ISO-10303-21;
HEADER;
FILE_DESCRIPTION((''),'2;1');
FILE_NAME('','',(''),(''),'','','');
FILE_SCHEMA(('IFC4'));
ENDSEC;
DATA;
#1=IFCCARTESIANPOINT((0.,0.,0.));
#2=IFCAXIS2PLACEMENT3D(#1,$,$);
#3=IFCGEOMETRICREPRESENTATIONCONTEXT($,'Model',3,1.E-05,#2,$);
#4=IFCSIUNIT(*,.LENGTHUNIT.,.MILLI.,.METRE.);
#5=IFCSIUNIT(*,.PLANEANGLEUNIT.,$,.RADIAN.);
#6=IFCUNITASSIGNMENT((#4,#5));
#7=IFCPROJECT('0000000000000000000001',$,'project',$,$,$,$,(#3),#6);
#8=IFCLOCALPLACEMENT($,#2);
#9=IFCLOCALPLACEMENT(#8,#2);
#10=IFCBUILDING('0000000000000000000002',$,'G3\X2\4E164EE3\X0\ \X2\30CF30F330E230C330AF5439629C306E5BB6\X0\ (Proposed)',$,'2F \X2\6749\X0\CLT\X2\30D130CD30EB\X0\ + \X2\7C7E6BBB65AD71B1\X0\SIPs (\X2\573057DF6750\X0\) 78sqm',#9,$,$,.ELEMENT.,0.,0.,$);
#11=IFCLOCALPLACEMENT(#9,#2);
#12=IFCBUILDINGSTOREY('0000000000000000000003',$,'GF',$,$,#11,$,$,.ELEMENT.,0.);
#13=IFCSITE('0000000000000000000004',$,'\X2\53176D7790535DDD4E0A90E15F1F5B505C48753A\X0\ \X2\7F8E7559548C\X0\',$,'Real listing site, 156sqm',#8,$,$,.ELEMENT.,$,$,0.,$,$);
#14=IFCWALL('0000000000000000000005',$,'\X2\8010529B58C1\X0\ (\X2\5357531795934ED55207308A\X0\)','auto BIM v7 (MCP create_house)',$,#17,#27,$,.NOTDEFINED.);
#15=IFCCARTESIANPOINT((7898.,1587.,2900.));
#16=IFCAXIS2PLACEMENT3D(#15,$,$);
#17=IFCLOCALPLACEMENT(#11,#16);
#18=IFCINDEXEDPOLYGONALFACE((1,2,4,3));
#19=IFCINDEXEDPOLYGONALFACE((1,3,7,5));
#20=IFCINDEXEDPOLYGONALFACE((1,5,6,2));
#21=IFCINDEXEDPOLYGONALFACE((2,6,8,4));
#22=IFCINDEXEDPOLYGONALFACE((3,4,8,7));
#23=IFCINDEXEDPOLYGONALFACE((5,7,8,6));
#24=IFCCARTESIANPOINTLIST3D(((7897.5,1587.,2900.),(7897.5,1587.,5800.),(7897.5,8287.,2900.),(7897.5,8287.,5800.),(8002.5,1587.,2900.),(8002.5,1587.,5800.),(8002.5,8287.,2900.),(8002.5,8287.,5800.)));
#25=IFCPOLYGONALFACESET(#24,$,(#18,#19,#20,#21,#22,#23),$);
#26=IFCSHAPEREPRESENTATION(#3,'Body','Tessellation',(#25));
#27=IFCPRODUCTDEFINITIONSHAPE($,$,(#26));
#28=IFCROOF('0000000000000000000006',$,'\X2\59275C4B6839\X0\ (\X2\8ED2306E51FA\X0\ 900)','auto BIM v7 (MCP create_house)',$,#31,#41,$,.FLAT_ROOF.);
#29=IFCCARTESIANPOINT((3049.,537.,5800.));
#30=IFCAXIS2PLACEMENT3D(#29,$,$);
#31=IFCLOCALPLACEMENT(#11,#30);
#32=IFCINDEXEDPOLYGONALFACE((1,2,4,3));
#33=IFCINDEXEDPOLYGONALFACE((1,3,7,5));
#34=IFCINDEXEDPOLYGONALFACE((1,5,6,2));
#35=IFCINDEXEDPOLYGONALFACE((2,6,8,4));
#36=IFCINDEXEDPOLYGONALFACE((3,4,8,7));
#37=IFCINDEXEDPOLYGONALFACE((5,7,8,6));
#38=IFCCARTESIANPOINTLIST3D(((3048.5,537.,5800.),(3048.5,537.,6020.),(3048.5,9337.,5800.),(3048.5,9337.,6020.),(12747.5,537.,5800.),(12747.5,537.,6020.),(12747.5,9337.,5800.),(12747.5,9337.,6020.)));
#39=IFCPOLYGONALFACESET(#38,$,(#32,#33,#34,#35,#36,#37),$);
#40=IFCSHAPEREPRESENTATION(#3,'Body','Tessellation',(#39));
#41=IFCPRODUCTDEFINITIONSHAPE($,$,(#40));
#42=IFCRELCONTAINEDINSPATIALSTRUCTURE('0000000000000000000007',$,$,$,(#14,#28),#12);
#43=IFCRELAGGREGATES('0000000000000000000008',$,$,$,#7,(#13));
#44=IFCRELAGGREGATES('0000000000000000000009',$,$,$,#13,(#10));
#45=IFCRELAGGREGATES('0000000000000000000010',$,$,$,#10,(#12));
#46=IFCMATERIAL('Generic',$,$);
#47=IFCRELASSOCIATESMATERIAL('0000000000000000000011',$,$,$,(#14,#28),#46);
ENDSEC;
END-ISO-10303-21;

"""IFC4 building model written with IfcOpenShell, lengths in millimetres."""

from ifc_helpers import new_model, si_unit, frame, frame_2d, origin, place, context, project, spatial, rectangle, extrude, material, element, save


model = new_model("IFC4")

# Units and contexts
model_context = context("Model", 3, precision=1e-05, world=origin())
ifc_project = project(units=[si_unit("LENGTHUNIT", "METRE", prefix="MILLI"), si_unit("PLANEANGLEUNIT", "RADIAN")], contexts=[model_context])

# Site, building, storey
site_placement = place(None, origin())
site = spatial("IfcSite", under=ifc_project, at=site_placement, Name="北海道川上郡弟子屈町 美留和", ObjectType="Real listing site, 156sqm", CompositionType="ELEMENT", RefElevation=0.0)
building_placement = place(site_placement, origin())
building = spatial("IfcBuilding", under=site, at=building_placement, Name="G3世代 ハンモック吹抜の家 (Proposed)", ObjectType="2F 杉CLTパネル + 籾殻断熱SIPs (地域材) 78sqm", CompositionType="ELEMENT", ElevationOfRefHeight=0.0, ElevationOfTerrain=0.0)
storey_placement = place(building_placement, origin())
storey = spatial("IfcBuildingStorey", under=building, at=storey_placement, Name="GF", CompositionType="ELEMENT", Elevation=0.0)

# Shared definitions
ifc_material = material(Name="Generic")

# Wall
wall_1_placement = place(storey_placement, frame((7898.0, 1587.0, 2900.0)))
element("IfcWall", 1, at=wall_1_placement, inside=storey, material=ifc_material, Name="耐力壁 (南北間仕切り)", Description="auto BIM v7 (MCP create_house)", PredefinedType="NOTDEFINED", context=model_context, shape_type="SweptSolid", body=[
    extrude(rectangle(XDim=105.0, YDim=6700.0, at=frame_2d((52.0, 3350.0))), frame((7898.0, 1587.0, 2900.0)), (0.0, 0.0, 1.0), 2900.0),
])

# Roof
roof_placement = place(storey_placement, frame((3049.0, 537.0, 5800.0)))
element("IfcRoof", 2, at=roof_placement, inside=storey, material=ifc_material, Name="大屋根 (軒の出 900)", Description="auto BIM v7 (MCP create_house)", PredefinedType="FLAT_ROOF", context=model_context, shape_type="SweptSolid", body=[
    extrude(rectangle(XDim=9699.0, YDim=8800.0, at=frame_2d((4849.0, 4400.0))), frame((3049.0, 537.0, 5800.0)), (0.0, 0.0, 1.0), 220.0),
])

save(model, "model.ifc")
